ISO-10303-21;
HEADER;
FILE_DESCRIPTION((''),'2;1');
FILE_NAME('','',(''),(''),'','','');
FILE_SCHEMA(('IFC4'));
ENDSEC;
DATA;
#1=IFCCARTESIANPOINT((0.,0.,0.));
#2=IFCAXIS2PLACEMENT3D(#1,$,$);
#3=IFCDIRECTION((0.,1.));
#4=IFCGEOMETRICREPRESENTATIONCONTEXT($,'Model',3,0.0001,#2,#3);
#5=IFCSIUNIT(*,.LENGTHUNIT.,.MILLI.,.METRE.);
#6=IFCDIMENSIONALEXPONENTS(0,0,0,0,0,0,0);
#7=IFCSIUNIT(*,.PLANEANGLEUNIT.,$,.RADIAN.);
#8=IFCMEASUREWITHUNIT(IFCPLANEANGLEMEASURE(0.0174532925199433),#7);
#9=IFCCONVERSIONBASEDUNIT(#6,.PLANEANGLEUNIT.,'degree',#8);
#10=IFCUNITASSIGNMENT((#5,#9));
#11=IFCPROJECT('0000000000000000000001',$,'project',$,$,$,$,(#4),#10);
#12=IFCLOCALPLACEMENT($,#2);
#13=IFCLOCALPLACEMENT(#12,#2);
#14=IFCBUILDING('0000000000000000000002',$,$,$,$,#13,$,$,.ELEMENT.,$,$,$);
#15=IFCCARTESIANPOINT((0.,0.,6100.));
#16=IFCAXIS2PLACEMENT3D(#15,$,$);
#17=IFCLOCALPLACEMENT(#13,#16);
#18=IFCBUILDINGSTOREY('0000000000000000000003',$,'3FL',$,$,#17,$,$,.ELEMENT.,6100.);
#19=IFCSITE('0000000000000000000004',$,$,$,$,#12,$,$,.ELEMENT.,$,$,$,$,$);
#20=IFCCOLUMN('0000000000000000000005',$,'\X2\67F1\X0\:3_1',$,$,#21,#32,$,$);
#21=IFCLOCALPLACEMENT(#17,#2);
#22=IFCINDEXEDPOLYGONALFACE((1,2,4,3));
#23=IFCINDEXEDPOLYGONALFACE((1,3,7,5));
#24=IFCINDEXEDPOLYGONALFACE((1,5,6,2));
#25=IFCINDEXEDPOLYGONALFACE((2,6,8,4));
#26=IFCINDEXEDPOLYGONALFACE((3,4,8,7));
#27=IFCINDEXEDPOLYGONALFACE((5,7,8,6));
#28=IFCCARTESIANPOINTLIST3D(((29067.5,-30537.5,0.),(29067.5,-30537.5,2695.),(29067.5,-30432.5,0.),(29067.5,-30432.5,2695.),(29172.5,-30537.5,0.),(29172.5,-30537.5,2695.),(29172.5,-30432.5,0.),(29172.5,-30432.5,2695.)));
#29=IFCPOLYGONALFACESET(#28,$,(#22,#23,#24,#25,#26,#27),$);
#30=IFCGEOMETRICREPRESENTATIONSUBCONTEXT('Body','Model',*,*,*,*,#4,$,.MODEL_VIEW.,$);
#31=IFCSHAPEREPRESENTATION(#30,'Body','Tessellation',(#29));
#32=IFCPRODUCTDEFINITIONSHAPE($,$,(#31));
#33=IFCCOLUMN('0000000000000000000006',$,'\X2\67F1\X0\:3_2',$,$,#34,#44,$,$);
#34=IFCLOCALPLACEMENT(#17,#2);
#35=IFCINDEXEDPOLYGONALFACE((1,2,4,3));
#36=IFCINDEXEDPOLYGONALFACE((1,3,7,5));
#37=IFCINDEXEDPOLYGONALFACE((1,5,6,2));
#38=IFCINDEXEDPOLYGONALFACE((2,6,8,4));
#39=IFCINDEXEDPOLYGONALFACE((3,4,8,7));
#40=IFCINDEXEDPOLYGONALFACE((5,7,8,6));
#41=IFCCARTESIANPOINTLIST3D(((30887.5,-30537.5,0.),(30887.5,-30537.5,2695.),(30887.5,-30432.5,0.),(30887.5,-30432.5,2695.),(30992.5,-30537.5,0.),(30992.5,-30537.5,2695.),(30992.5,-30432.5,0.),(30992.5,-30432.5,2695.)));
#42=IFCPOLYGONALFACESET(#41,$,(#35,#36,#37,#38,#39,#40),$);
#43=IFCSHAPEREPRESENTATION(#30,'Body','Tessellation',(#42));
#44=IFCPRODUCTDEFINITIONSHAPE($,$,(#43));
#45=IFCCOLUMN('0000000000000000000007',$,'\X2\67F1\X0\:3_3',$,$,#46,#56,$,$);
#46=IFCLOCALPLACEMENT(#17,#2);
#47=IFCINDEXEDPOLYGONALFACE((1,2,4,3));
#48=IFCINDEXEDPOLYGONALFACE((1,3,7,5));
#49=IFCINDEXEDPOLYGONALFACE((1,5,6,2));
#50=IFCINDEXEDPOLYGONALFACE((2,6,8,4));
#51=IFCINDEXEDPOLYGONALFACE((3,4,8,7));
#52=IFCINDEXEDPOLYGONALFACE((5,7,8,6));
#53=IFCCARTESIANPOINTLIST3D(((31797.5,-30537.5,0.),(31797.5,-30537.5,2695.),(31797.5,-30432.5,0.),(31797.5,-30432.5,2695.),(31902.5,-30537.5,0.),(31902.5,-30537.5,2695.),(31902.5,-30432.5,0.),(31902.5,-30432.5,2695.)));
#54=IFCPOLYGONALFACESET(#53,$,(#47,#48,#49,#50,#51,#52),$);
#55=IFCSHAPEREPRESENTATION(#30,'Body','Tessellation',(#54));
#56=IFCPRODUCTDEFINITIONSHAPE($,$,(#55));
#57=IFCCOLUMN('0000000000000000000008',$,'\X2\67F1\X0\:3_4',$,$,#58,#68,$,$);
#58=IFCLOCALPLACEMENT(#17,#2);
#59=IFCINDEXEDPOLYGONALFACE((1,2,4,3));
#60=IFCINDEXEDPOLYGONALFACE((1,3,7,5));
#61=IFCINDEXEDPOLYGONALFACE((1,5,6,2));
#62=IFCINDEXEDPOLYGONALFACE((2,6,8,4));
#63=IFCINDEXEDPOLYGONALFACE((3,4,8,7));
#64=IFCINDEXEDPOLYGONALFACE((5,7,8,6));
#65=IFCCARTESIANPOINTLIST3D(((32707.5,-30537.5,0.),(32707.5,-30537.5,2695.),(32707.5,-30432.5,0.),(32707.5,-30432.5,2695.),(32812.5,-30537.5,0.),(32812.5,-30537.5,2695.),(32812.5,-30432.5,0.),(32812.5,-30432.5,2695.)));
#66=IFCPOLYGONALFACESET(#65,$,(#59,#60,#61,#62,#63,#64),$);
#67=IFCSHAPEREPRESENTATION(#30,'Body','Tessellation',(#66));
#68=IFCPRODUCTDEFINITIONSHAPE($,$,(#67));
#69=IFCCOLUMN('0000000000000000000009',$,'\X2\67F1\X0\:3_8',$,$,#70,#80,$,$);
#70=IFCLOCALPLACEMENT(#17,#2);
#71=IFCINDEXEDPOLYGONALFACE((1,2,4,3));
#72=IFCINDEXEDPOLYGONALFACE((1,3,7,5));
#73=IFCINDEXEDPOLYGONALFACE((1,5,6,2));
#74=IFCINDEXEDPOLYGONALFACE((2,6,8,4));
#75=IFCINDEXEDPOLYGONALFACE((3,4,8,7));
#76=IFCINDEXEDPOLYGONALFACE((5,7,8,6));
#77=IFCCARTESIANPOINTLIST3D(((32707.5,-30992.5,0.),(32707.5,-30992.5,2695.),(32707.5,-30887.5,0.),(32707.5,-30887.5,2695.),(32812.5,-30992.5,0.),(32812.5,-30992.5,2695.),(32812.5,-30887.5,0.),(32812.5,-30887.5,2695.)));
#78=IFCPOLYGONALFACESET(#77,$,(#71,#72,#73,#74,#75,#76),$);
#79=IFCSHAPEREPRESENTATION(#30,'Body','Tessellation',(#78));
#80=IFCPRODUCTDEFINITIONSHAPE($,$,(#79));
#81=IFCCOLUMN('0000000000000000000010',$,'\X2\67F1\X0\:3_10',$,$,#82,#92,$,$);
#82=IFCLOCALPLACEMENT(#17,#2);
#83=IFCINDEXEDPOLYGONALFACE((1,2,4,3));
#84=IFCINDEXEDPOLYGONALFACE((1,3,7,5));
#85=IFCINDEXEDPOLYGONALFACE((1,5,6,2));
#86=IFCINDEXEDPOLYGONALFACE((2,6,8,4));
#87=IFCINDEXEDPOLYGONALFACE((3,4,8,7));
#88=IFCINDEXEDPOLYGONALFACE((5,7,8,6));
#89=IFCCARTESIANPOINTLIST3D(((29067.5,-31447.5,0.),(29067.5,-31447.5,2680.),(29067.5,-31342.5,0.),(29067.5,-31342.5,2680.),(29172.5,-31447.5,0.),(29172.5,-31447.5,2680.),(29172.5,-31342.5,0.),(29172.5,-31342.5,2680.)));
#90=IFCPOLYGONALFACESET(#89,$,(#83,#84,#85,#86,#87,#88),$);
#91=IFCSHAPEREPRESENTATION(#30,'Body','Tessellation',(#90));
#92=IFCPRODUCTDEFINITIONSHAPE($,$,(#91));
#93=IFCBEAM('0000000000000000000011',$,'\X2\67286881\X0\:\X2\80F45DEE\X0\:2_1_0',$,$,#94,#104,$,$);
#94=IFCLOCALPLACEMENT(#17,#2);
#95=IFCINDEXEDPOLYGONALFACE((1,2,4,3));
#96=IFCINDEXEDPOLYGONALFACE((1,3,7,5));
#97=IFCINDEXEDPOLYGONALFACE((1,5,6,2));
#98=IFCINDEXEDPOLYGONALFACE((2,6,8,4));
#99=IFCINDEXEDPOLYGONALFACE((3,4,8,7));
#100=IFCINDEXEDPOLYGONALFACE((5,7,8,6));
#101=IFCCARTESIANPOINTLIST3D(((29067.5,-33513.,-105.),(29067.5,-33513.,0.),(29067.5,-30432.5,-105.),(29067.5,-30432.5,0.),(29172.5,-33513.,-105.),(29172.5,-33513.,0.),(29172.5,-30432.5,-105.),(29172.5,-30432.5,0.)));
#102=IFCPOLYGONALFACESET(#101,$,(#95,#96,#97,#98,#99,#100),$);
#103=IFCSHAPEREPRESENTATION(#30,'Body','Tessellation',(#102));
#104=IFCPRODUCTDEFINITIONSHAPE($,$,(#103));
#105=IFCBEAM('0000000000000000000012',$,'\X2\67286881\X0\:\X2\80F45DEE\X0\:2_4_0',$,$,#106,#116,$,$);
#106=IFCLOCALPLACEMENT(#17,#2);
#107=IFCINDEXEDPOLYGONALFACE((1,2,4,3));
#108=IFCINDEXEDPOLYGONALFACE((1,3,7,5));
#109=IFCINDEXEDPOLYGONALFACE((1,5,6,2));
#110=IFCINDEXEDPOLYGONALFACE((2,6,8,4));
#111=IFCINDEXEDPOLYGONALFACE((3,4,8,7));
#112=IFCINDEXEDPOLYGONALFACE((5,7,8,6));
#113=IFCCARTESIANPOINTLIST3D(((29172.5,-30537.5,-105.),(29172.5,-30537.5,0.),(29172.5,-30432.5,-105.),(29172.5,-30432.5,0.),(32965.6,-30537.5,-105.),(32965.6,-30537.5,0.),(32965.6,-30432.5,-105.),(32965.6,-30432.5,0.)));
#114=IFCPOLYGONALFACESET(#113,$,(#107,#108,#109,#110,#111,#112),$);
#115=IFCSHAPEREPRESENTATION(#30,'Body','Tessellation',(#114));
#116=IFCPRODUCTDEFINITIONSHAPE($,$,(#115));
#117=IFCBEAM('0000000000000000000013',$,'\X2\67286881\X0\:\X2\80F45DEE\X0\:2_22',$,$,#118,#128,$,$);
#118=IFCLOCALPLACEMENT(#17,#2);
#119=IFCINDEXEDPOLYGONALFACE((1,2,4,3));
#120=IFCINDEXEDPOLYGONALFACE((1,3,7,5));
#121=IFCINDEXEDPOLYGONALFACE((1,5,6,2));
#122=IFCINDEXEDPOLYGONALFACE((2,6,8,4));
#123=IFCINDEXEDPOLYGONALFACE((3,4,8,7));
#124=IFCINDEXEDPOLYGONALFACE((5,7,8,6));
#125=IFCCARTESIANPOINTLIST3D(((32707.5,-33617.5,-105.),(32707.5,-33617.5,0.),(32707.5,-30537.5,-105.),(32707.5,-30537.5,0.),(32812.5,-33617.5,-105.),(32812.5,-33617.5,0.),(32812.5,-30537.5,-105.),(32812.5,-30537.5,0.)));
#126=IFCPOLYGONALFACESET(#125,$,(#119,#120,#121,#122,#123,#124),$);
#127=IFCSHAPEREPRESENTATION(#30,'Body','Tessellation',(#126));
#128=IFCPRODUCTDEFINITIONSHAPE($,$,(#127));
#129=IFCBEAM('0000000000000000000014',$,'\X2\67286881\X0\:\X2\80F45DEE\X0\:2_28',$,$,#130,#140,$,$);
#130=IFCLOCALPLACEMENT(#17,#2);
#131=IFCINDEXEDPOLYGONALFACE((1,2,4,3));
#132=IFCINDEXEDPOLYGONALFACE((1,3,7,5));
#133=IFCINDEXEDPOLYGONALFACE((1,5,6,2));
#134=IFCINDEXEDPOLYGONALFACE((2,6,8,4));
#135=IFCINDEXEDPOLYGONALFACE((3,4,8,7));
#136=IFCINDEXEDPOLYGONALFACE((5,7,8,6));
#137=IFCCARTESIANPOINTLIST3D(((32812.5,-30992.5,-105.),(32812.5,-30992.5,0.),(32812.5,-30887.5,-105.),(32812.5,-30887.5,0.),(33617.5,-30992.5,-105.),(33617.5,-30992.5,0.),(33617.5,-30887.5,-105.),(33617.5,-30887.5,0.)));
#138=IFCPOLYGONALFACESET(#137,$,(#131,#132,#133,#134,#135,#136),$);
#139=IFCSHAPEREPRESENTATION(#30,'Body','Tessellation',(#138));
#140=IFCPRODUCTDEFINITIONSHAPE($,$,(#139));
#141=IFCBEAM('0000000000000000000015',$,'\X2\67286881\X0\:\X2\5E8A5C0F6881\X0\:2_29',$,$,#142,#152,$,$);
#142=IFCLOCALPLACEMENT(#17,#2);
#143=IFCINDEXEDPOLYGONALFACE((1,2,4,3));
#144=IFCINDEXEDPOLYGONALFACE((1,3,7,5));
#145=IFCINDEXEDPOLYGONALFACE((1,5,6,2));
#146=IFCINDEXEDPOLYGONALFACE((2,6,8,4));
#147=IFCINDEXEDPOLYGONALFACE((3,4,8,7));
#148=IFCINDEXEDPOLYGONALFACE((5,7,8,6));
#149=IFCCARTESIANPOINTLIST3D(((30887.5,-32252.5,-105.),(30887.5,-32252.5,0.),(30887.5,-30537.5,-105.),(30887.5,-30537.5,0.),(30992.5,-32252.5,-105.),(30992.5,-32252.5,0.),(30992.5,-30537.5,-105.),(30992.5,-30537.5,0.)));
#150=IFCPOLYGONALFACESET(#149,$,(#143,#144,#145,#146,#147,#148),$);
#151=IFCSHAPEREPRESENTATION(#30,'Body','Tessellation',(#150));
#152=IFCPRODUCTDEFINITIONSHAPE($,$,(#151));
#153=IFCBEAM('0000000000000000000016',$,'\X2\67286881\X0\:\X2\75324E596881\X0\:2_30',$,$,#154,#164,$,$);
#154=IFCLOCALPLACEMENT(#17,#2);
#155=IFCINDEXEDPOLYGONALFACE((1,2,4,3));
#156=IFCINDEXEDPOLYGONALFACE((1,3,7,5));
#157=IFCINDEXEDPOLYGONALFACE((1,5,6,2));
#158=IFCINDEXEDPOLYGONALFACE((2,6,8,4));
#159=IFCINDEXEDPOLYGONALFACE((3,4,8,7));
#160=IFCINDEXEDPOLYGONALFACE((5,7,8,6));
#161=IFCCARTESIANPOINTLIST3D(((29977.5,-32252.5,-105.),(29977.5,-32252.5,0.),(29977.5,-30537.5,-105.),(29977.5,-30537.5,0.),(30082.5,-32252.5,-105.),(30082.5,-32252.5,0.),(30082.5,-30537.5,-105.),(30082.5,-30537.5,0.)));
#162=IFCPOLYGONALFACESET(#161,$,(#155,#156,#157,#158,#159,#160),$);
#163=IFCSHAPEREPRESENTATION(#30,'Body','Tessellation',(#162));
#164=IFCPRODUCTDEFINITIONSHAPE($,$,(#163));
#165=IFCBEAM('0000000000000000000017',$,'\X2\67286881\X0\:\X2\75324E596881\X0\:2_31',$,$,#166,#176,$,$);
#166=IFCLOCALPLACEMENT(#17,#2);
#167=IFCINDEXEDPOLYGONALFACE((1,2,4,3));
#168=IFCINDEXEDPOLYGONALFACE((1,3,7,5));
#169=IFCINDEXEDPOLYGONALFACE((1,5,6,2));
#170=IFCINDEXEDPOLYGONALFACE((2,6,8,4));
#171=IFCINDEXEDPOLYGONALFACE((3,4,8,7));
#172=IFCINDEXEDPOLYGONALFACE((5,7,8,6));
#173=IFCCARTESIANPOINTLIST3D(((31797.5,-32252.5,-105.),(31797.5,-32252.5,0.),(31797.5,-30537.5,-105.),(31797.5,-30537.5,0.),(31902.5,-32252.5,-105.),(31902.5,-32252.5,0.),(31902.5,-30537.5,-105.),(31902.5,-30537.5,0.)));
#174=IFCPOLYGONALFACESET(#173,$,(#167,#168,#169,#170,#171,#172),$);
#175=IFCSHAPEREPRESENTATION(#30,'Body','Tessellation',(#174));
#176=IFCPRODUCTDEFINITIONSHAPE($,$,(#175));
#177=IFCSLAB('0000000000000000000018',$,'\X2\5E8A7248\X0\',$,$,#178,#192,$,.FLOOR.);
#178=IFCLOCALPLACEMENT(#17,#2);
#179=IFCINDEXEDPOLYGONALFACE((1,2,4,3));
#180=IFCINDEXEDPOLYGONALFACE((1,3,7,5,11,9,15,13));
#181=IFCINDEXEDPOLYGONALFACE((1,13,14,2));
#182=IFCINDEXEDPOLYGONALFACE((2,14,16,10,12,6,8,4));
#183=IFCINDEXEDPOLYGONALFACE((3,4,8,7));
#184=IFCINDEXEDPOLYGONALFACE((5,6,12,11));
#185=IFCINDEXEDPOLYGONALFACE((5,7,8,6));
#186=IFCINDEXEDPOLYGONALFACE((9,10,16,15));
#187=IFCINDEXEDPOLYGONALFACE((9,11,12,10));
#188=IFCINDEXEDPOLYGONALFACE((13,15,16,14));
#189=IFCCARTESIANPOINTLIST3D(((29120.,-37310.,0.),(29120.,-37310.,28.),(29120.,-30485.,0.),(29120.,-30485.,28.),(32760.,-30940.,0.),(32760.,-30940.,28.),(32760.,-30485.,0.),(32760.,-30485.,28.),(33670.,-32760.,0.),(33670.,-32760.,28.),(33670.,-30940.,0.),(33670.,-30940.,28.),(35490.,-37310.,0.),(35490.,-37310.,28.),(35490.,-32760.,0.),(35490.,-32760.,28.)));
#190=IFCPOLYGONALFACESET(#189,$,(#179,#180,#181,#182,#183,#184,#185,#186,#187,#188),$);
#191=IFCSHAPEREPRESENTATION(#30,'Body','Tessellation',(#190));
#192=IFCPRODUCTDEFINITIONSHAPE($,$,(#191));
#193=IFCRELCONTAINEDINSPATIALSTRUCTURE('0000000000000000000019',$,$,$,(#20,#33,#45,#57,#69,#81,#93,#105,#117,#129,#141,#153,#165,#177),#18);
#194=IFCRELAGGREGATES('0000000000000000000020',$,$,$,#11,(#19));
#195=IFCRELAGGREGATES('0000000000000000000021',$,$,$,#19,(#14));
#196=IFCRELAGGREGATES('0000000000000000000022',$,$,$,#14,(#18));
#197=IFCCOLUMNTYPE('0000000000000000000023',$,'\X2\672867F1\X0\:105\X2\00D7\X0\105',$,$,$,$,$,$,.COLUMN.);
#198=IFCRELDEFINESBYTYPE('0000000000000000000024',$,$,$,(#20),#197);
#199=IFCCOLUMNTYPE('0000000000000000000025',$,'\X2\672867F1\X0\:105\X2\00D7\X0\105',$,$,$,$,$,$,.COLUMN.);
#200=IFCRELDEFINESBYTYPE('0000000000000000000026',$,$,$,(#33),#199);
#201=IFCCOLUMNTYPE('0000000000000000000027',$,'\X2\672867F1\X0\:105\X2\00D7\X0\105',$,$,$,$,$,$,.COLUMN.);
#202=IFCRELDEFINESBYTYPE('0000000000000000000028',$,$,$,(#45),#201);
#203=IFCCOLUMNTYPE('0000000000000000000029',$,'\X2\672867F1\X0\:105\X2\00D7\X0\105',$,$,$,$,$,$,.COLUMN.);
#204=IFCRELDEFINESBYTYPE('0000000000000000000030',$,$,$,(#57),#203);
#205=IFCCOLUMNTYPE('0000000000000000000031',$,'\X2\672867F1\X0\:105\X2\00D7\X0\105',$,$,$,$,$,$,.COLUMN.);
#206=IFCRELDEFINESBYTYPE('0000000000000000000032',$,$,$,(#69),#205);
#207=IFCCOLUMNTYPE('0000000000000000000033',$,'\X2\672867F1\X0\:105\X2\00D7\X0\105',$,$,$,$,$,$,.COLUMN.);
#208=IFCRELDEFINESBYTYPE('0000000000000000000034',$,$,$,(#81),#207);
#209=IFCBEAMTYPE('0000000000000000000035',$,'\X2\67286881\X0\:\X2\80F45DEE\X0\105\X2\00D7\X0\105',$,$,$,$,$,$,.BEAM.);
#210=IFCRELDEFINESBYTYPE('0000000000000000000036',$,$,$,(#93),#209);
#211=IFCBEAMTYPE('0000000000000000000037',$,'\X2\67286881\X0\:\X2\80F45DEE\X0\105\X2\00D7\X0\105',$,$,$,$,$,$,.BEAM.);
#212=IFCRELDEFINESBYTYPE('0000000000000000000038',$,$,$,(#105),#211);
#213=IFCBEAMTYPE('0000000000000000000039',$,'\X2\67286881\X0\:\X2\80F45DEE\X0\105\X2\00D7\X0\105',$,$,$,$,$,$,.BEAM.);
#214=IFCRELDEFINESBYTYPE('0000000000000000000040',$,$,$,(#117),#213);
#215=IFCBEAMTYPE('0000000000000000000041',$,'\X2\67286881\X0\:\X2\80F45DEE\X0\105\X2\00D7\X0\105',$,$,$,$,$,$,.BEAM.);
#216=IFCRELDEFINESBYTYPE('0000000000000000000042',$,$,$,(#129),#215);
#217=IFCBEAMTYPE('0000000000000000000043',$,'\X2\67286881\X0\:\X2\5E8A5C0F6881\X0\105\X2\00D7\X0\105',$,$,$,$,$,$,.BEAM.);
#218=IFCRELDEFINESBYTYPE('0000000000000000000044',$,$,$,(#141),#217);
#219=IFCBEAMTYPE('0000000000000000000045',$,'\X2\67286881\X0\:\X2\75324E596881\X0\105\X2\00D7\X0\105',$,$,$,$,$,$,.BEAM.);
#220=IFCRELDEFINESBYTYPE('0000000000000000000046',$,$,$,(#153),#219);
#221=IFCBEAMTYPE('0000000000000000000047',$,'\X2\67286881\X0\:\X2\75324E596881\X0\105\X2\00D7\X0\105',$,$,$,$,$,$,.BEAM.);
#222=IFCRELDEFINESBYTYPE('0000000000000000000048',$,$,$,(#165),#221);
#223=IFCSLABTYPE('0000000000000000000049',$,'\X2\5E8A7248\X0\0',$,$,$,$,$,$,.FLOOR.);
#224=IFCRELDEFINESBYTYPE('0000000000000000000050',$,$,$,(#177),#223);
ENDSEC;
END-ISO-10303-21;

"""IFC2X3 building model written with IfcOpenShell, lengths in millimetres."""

from ifc_helpers import new_model, entity, si_unit, converted_unit, direction, frame, origin, origin_with_axes, origin_2d, place, context, subcontext, project, spatial, polyline, rectangle, outline, extrude, type_object, element, save


model = new_model("IFC2X3")

# Units and contexts
model_context = context("Model", 3, precision=0.0001, world=origin(), true_north=direction((0.0, 1.0)))
body_context = subcontext(model_context, "Body", "Model", "MODEL_VIEW")
ifc_project = project(units=[si_unit("LENGTHUNIT", "METRE", prefix="MILLI"), converted_unit("PLANEANGLEUNIT", "degree", entity("IfcPlaneAngleMeasure", 0.0174532925199433), si_unit("PLANEANGLEUNIT", "RADIAN"), dimensions=[0, 0, 0, 0, 0, 0, 0])], contexts=[model_context])

# Site, building, storey
site_placement = place(None, origin())
site = spatial("IfcSite", under=ifc_project, at=site_placement, CompositionType="ELEMENT")
building_placement = place(site_placement, origin())
building = spatial("IfcBuilding", under=site, at=building_placement, CompositionType="ELEMENT")
storey_placement = place(building_placement, frame((0.0, 0.0, 6100.0)))
storey = spatial("IfcBuildingStorey", under=building, at=storey_placement, Name="3FL", CompositionType="ELEMENT", Elevation=6100.0)

# Columns
column_type_1 = type_object("IfcColumnType", Name="木柱:105×105", PredefinedType="COLUMN")
column_1_placement = place(storey_placement, frame((29120.0, -30485.0, 0.0)))
element("IfcColumn", 1, at=column_1_placement, inside=storey, type_object=column_type_1, Name="柱:3_1", context=body_context, shape_type="SweptSolid", body=[
    extrude(rectangle(XDim=105.0, YDim=105.0, at=origin_2d()), origin_with_axes(), (0.0, 0.0, 1.0), 2695.0),
])
column_type_2 = type_object("IfcColumnType", Name="木柱:105×105", PredefinedType="COLUMN")
column_2_placement = place(storey_placement, frame((30940.0, -30485.0, 0.0)))
element("IfcColumn", 2, at=column_2_placement, inside=storey, type_object=column_type_2, Name="柱:3_2", context=body_context, shape_type="SweptSolid", body=[
    extrude(rectangle(XDim=105.0, YDim=105.0, at=origin_2d()), origin_with_axes(), (0.0, 0.0, 1.0), 2695.0),
])
column_type_3 = type_object("IfcColumnType", Name="木柱:105×105", PredefinedType="COLUMN")
column_3_placement = place(storey_placement, frame((31850.0, -30485.0, 0.0)))
element("IfcColumn", 3, at=column_3_placement, inside=storey, type_object=column_type_3, Name="柱:3_3", context=body_context, shape_type="SweptSolid", body=[
    extrude(rectangle(XDim=105.0, YDim=105.0, at=origin_2d()), origin_with_axes(), (0.0, 0.0, 1.0), 2695.0),
])
column_type_4 = type_object("IfcColumnType", Name="木柱:105×105", PredefinedType="COLUMN")
column_4_placement = place(storey_placement, frame((32760.0, -30485.0, 0.0)))
element("IfcColumn", 4, at=column_4_placement, inside=storey, type_object=column_type_4, Name="柱:3_4", context=body_context, shape_type="SweptSolid", body=[
    extrude(rectangle(XDim=105.0, YDim=105.0, at=origin_2d()), origin_with_axes(), (0.0, 0.0, 1.0), 2695.0),
])
column_type_5 = type_object("IfcColumnType", Name="木柱:105×105", PredefinedType="COLUMN")
column_5_placement = place(storey_placement, frame((32760.0, -30940.0, 0.0)))
element("IfcColumn", 5, at=column_5_placement, inside=storey, type_object=column_type_5, Name="柱:3_8", context=body_context, shape_type="SweptSolid", body=[
    extrude(rectangle(XDim=105.0, YDim=105.0, at=origin_2d()), origin_with_axes(), (0.0, 0.0, 1.0), 2695.0),
])
column_type_6 = type_object("IfcColumnType", Name="木柱:105×105", PredefinedType="COLUMN")
column_6_placement = place(storey_placement, frame((29120.0, -31395.0, 0.0)))
element("IfcColumn", 6, at=column_6_placement, inside=storey, type_object=column_type_6, Name="柱:3_10", context=body_context, shape_type="SweptSolid", body=[
    extrude(rectangle(XDim=105.0, YDim=105.0, at=origin_2d()), origin_with_axes(), (0.0, 0.0, 1.0), 2680.0),
])

# Beams
beam_type_1 = type_object("IfcBeamType", Name="木梁:胴差105×105", PredefinedType="BEAM")
beam_1_placement = place(storey_placement, frame((29120.0, -30432.5, -52.5), z_axis=(0.0, -1.0, 0.0), x_axis=(1.0, 0.0, 0.0)))
element("IfcBeam", 7, at=beam_1_placement, inside=storey, type_object=beam_type_1, Name="木梁:胴差:2_1_0", context=body_context, shape_type="SweptSolid", body=[
    extrude(rectangle(XDim=105.0, YDim=105.0, at=origin_2d()), origin_with_axes(), (0.0, 0.0, 1.0), 3080.5),
])
beam_type_2 = type_object("IfcBeamType", Name="木梁:胴差105×105", PredefinedType="BEAM")
beam_2_placement = place(storey_placement, frame((29172.5, -30485.0, -52.5), z_axis=(1.0, 0.0, 0.0), x_axis=(0.0, 1.0, 0.0)))
element("IfcBeam", 8, at=beam_2_placement, inside=storey, type_object=beam_type_2, Name="木梁:胴差:2_4_0", context=body_context, shape_type="SweptSolid", body=[
    extrude(rectangle(XDim=105.0, YDim=105.0, at=origin_2d()), origin_with_axes(), (0.0, 0.0, 1.0), 3793.1),
])
beam_type_3 = type_object("IfcBeamType", Name="木梁:胴差105×105", PredefinedType="BEAM")
beam_3_placement = place(storey_placement, frame((32760.0, -30537.5, -52.5), z_axis=(0.0, -1.0, 0.0), x_axis=(1.0, 0.0, 0.0)))
element("IfcBeam", 9, at=beam_3_placement, inside=storey, type_object=beam_type_3, Name="木梁:胴差:2_22", context=body_context, shape_type="SweptSolid", body=[
    extrude(rectangle(XDim=105.0, YDim=105.0, at=origin_2d()), origin_with_axes(), (0.0, 0.0, 1.0), 3080.0),
])
beam_type_4 = type_object("IfcBeamType", Name="木梁:胴差105×105", PredefinedType="BEAM")
beam_4_placement = place(storey_placement, frame((32812.5, -30940.0, -52.5), z_axis=(1.0, 0.0, 0.0), x_axis=(0.0, 1.0, 0.0)))
element("IfcBeam", 10, at=beam_4_placement, inside=storey, type_object=beam_type_4, Name="木梁:胴差:2_28", context=body_context, shape_type="SweptSolid", body=[
    extrude(rectangle(XDim=105.0, YDim=105.0, at=origin_2d()), origin_with_axes(), (0.0, 0.0, 1.0), 805.0),
])
beam_type_5 = type_object("IfcBeamType", Name="木梁:床小梁105×105", PredefinedType="BEAM")
beam_5_placement = place(storey_placement, frame((30940.0, -30537.5, -52.5), z_axis=(0.0, -1.0, 0.0), x_axis=(1.0, 0.0, 0.0)))
element("IfcBeam", 11, at=beam_5_placement, inside=storey, type_object=beam_type_5, Name="木梁:床小梁:2_29", context=body_context, shape_type="SweptSolid", body=[
    extrude(rectangle(XDim=105.0, YDim=105.0, at=origin_2d()), origin_with_axes(), (0.0, 0.0, 1.0), 1715.0),
])
beam_type_6 = type_object("IfcBeamType", Name="木梁:甲乙梁105×105", PredefinedType="BEAM")
beam_6_placement = place(storey_placement, frame((30030.0, -30537.5, -52.5), z_axis=(0.0, -1.0, 0.0), x_axis=(1.0, 0.0, 0.0)))
element("IfcBeam", 12, at=beam_6_placement, inside=storey, type_object=beam_type_6, Name="木梁:甲乙梁:2_30", context=body_context, shape_type="SweptSolid", body=[
    extrude(rectangle(XDim=105.0, YDim=105.0, at=origin_2d()), origin_with_axes(), (0.0, 0.0, 1.0), 1715.0),
])
beam_type_7 = type_object("IfcBeamType", Name="木梁:甲乙梁105×105", PredefinedType="BEAM")
beam_7_placement = place(storey_placement, frame((31850.0, -30537.5, -52.5), z_axis=(0.0, -1.0, 0.0), x_axis=(1.0, 0.0, 0.0)))
element("IfcBeam", 13, at=beam_7_placement, inside=storey, type_object=beam_type_7, Name="木梁:甲乙梁:2_31", context=body_context, shape_type="SweptSolid", body=[
    extrude(rectangle(XDim=105.0, YDim=105.0, at=origin_2d()), origin_with_axes(), (0.0, 0.0, 1.0), 1715.0),
])

# Slab
slab_type = type_object("IfcSlabType", Name="床版0", PredefinedType="FLOOR")
slab_placement = place(storey_placement, origin_with_axes())
element("IfcSlab", 14, at=slab_placement, inside=storey, type_object=slab_type, Name="床版", PredefinedType="FLOOR", context=body_context, shape_type="SweptSolid", body=[
    extrude(outline(polyline([(35490.0, -32760.0, 0.0), (33670.0, -32760.0, 0.0), (33670.0, -30940.0, 0.0), (32760.0, -30940.0, 0.0), (32760.0, -30485.0, 0.0), (29120.0, -30485.0, 0.0), (29120.0, -37310.0, 0.0), (35490.0, -37310.0, 0.0), (35490.0, -32760.0, 0.0)])), origin_with_axes(), (0.0, 0.0, 1.0), 28.0),
])

save(model, "model.ifc")
